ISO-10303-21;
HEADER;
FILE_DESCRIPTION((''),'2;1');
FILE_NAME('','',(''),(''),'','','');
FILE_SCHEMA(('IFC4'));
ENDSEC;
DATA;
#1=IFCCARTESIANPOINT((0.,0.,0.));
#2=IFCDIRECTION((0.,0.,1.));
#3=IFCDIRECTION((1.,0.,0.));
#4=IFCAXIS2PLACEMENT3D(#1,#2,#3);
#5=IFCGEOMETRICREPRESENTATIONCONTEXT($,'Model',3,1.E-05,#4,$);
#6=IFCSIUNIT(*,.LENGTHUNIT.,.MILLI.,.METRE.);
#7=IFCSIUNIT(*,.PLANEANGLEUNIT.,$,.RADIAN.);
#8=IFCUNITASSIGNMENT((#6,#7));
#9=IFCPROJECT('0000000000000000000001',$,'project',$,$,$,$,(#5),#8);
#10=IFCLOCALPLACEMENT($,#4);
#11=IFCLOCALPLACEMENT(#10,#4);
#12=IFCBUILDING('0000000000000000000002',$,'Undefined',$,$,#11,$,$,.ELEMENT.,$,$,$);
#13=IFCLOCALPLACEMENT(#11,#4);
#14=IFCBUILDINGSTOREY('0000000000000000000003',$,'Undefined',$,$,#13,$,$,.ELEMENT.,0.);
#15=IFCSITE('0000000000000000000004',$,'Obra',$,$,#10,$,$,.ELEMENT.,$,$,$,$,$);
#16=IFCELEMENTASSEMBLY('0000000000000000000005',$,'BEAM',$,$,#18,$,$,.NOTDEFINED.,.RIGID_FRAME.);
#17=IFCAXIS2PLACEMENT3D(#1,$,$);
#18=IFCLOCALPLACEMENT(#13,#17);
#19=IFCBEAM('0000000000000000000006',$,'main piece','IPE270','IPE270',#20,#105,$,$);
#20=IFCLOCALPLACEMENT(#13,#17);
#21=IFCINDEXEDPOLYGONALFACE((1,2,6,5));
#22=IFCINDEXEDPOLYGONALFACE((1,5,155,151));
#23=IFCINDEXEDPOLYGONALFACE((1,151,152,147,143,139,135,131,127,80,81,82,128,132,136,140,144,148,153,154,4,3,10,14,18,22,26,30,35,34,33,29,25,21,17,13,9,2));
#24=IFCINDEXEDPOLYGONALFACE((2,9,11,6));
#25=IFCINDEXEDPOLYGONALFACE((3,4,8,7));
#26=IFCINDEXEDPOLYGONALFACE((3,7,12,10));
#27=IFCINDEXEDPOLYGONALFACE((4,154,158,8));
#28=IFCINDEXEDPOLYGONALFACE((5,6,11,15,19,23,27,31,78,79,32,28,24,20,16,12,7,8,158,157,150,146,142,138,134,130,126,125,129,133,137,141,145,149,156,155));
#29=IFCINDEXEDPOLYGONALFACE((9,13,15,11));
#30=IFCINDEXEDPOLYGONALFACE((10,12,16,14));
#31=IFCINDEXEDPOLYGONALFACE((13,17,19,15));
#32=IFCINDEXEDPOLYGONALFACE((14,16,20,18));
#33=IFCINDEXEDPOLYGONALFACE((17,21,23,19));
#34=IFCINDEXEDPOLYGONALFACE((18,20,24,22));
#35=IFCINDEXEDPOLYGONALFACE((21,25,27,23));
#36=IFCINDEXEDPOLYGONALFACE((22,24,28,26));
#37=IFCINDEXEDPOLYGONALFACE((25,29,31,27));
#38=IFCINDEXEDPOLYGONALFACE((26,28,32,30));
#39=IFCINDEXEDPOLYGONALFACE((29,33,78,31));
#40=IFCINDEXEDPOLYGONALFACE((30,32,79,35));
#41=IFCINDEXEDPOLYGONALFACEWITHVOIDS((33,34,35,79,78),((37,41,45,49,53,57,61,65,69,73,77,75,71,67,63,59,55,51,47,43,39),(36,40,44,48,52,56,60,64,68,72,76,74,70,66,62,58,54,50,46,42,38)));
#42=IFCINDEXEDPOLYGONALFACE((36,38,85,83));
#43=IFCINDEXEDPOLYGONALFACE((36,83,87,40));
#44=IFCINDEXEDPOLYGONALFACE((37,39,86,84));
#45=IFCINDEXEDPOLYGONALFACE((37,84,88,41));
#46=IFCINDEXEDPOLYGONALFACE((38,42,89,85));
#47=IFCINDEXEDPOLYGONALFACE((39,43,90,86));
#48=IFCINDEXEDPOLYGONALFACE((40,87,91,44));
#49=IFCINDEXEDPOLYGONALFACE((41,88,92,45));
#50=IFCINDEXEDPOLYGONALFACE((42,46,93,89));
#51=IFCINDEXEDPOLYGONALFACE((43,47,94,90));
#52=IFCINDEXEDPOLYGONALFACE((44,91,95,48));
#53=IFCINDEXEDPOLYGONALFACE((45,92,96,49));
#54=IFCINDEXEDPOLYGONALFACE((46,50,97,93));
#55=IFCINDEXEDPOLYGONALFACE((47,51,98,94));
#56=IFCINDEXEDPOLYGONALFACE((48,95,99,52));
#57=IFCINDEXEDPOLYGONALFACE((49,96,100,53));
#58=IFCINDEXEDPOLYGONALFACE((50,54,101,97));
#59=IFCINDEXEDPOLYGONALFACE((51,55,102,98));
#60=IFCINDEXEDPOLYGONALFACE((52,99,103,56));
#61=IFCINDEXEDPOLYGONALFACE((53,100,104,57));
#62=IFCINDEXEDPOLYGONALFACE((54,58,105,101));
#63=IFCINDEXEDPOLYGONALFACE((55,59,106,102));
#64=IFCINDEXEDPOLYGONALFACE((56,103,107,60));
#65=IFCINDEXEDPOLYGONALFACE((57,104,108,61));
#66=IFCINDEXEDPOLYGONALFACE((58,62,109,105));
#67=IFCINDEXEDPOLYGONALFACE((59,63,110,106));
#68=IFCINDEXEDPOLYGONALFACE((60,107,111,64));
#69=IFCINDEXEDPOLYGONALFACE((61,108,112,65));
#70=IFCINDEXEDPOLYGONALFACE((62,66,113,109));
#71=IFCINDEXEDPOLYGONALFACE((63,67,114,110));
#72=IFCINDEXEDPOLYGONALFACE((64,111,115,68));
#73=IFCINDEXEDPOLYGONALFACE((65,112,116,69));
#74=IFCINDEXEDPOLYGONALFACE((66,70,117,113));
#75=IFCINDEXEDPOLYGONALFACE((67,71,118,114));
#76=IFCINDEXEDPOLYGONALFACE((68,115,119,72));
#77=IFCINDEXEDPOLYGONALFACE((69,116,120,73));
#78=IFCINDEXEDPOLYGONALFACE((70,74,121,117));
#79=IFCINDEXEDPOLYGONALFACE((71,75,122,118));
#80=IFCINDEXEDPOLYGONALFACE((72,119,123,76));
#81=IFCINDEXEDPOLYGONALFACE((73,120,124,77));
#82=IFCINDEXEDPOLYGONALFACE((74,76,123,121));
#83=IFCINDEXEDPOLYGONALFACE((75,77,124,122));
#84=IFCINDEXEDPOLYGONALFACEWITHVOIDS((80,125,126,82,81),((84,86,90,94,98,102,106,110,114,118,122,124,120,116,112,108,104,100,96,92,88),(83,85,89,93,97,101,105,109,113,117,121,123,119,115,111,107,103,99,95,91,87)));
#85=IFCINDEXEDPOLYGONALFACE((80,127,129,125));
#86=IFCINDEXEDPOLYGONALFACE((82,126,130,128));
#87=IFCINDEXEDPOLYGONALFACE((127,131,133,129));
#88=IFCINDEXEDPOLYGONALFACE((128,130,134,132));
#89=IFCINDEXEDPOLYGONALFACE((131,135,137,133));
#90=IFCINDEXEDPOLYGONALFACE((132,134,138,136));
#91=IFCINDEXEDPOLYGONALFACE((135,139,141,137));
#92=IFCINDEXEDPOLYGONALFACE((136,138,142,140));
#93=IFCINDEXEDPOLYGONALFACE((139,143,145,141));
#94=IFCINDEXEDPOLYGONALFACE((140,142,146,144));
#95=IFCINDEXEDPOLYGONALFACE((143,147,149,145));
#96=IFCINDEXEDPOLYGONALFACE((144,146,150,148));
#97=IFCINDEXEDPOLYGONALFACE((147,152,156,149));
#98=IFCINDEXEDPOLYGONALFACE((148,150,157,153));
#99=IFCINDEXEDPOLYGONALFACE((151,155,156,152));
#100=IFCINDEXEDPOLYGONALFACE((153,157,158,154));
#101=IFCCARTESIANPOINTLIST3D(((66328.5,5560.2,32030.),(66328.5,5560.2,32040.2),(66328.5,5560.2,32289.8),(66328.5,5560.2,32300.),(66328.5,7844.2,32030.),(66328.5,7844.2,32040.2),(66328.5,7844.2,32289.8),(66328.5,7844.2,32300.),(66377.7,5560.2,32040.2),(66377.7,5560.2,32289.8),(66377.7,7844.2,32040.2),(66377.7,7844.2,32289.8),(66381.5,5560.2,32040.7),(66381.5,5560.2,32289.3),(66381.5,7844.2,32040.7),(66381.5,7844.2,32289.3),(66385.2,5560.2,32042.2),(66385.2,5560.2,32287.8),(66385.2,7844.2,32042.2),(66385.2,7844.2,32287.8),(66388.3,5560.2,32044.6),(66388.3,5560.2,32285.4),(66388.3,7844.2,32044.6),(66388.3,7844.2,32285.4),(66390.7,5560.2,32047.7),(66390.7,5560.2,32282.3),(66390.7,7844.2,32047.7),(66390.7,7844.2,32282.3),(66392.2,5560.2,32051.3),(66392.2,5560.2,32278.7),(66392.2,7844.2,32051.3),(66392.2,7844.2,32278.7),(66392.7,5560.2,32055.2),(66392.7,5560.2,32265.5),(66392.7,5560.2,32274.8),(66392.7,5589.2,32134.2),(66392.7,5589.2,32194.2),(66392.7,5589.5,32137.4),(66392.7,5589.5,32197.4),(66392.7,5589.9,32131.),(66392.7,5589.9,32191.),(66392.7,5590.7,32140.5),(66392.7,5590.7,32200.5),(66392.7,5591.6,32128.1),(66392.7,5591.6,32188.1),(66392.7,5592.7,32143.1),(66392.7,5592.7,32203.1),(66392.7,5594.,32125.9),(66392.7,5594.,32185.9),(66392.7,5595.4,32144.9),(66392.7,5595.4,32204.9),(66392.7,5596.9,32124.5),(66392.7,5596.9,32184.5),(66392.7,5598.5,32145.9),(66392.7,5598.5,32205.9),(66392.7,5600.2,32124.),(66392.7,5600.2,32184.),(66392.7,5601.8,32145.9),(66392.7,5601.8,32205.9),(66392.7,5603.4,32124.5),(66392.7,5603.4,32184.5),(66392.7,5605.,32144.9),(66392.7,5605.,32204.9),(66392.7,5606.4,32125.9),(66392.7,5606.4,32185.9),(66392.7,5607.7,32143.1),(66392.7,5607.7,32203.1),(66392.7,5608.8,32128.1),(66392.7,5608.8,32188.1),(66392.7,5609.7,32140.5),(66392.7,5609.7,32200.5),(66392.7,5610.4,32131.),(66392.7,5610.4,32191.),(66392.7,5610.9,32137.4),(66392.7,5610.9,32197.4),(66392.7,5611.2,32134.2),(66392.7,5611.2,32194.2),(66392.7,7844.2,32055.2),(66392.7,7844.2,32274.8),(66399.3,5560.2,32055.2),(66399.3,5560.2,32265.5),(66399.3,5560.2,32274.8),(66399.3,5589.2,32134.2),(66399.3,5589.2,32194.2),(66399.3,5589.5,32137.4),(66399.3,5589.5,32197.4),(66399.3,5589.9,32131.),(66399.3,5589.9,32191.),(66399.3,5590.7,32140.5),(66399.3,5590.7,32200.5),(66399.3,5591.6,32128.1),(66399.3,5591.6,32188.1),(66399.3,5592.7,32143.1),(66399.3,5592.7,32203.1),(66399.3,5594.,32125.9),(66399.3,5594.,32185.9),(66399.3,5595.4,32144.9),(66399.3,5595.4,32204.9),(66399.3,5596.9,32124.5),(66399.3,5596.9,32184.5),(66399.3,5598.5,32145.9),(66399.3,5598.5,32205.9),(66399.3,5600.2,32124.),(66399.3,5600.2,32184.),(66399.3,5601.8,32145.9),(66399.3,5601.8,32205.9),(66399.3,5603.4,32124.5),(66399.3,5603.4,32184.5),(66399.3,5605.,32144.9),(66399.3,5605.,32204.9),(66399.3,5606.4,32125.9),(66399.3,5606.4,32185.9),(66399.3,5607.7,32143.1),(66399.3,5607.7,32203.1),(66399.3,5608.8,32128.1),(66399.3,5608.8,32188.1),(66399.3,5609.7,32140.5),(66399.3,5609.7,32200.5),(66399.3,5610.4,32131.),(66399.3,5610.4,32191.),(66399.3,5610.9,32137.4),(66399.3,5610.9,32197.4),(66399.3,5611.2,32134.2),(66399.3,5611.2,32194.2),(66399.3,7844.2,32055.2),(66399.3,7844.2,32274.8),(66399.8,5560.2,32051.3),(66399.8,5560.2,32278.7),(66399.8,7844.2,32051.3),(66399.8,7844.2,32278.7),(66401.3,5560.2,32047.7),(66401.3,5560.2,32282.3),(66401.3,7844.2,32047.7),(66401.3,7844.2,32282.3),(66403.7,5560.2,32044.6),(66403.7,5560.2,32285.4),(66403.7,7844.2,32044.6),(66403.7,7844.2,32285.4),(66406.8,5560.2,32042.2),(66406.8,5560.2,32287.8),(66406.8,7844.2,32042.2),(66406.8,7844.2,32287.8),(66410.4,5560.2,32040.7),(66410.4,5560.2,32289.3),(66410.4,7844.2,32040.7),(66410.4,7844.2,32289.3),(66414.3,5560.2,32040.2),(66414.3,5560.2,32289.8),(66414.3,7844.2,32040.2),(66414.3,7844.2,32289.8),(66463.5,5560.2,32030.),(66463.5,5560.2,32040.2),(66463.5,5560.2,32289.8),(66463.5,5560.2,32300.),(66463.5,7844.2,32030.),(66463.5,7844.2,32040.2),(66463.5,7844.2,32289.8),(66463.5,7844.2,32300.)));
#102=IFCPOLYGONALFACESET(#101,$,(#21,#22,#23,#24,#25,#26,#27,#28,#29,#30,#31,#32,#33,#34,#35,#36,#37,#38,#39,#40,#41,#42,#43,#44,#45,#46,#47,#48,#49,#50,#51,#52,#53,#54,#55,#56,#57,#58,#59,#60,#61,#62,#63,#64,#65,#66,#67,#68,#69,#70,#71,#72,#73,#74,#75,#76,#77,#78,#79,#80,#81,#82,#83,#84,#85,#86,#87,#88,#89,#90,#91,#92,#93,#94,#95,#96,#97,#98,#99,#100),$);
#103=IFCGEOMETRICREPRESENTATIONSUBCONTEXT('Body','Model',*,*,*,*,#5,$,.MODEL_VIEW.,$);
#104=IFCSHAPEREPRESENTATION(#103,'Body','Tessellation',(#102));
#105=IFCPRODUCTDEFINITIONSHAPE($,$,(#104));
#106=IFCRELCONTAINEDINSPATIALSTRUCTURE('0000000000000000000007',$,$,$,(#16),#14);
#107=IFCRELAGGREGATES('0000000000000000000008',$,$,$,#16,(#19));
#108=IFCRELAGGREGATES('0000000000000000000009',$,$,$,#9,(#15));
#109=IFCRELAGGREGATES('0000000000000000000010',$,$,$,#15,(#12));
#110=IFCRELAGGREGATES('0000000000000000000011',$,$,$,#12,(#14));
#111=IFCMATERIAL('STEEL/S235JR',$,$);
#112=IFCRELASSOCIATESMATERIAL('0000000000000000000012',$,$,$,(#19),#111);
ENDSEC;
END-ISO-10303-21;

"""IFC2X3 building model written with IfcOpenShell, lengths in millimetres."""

from ifc_helpers import new_model, si_unit, frame, origin_with_axes, origin_2d_with_axis, place, context, subcontext, project, spatial, rectangle, circle, i_section, extrude, clip, halfspace, source, transform, mapped, material, element, aggregate, save


model = new_model("IFC2X3")

# Units and contexts
model_context = context("Model", 3, precision=1e-05, world=origin_with_axes())
body_context = subcontext(model_context, "Body", "Model", "MODEL_VIEW")
ifc_project = project(units=[si_unit("LENGTHUNIT", "METRE", prefix="MILLI"), si_unit("PLANEANGLEUNIT", "RADIAN")], contexts=[model_context])

# Site, building, storey
site_placement = place(None, origin_with_axes())
site = spatial("IfcSite", under=ifc_project, at=site_placement, Name="Obra", CompositionType="ELEMENT")
building_placement = place(site_placement, origin_with_axes())
building = spatial("IfcBuilding", under=site, at=building_placement, Name="Undefined", CompositionType="ELEMENT")
storey_placement = place(building_placement, origin_with_axes())
storey = spatial("IfcBuildingStorey", under=building, at=storey_placement, Name="Undefined", CompositionType="ELEMENT", Elevation=0.0)

# Shared definitions
ifc_material_1 = material(Name="STEEL/S235JR")

# Element assembly, beam, openings
assembly_1_placement = place(storey_placement, origin_with_axes())
assembly_1 = element("IfcElementAssembly", 1, at=assembly_1_placement, inside=storey, Name="BEAM", AssemblyPlace="NOTDEFINED", PredefinedType="RIGID_FRAME")
beam_1_placement = place(assembly_1_placement, frame((66396.0, 5562.9, 32165.0), z_axis=(0.0, 0.0, 1.0), x_axis=(0.0, 1.0, 0.0)))
beam_1 = element("IfcBeam", 2, at=beam_1_placement, material=ifc_material_1, Name="main piece", Description="IPE270", ObjectType="IPE270", context=body_context, shape_type="Clipping", body=[
    clip(extrude(i_section(OverallWidth=135.0, OverallDepth=270.0, WebThickness=6.6, FlangeThickness=10.2, FilletRadius=15.0, at=origin_2d_with_axis()), frame((2281.3, 0.0, 0.0), z_axis=(-1.0, 0.0, 0.0), x_axis=(0.0, -1.0, 0.0)), (0.0, 0.0, 1.0), 2284.0), halfspace(frame((-2.7, 0.0, -235.0), z_axis=(1.0, 0.0, 0.0), x_axis=(0.0, -1.0, 0.0)), True)),
])
opening_1_placement = place(assembly_1_placement, frame((66396.0, 5562.9, 32165.0), z_axis=(0.0, 0.0, 1.0), x_axis=(0.0, 1.0, 0.0)))
element("IfcOpeningElement", 3, at=opening_1_placement, cuts=beam_1, ObjectType="Recess", context=body_context, shape_type="SweptSolid", body=[
    extrude(rectangle(XDim=35.5, YDim=97.7, at=origin_2d_with_axis()), frame((-51.6, -68.5, 118.2), z_axis=(0.0, 1.0, 0.0), x_axis=(0.0, 0.0, -1.0)), (0.0, 0.0, 1.0), 137.0),
])
shared_shape_1 = source(origin_with_axes(), body_context, "Body", "SweptSolid", [
    extrude(circle(Radius=11.0, at=origin_2d_with_axis()), frame((0.0, -3.4, 0.0), z_axis=(0.0, 1.0, 0.0), x_axis=(1.0, 0.0, 0.0)), (0.0, 0.0, 1.0), 6.8),
])
opening_2_placement = place(assembly_1_placement, frame((66396.0, 5560.2, 32235.0), z_axis=(0.0, 1.0, 0.0), x_axis=(0.0, 0.0, -1.0)))
element("IfcOpeningElement", 4, at=opening_2_placement, cuts=beam_1, ObjectType="Opening", context=body_context, shape_type="MappedRepresentation", body=[
    mapped(shared_shape_1, transform((40.0, 0.0, 40.0))),
    mapped(shared_shape_1, transform((100.0, 0.0, 40.0))),
])

aggregate(assembly_1, [beam_1])

save(model, "model.ifc")
